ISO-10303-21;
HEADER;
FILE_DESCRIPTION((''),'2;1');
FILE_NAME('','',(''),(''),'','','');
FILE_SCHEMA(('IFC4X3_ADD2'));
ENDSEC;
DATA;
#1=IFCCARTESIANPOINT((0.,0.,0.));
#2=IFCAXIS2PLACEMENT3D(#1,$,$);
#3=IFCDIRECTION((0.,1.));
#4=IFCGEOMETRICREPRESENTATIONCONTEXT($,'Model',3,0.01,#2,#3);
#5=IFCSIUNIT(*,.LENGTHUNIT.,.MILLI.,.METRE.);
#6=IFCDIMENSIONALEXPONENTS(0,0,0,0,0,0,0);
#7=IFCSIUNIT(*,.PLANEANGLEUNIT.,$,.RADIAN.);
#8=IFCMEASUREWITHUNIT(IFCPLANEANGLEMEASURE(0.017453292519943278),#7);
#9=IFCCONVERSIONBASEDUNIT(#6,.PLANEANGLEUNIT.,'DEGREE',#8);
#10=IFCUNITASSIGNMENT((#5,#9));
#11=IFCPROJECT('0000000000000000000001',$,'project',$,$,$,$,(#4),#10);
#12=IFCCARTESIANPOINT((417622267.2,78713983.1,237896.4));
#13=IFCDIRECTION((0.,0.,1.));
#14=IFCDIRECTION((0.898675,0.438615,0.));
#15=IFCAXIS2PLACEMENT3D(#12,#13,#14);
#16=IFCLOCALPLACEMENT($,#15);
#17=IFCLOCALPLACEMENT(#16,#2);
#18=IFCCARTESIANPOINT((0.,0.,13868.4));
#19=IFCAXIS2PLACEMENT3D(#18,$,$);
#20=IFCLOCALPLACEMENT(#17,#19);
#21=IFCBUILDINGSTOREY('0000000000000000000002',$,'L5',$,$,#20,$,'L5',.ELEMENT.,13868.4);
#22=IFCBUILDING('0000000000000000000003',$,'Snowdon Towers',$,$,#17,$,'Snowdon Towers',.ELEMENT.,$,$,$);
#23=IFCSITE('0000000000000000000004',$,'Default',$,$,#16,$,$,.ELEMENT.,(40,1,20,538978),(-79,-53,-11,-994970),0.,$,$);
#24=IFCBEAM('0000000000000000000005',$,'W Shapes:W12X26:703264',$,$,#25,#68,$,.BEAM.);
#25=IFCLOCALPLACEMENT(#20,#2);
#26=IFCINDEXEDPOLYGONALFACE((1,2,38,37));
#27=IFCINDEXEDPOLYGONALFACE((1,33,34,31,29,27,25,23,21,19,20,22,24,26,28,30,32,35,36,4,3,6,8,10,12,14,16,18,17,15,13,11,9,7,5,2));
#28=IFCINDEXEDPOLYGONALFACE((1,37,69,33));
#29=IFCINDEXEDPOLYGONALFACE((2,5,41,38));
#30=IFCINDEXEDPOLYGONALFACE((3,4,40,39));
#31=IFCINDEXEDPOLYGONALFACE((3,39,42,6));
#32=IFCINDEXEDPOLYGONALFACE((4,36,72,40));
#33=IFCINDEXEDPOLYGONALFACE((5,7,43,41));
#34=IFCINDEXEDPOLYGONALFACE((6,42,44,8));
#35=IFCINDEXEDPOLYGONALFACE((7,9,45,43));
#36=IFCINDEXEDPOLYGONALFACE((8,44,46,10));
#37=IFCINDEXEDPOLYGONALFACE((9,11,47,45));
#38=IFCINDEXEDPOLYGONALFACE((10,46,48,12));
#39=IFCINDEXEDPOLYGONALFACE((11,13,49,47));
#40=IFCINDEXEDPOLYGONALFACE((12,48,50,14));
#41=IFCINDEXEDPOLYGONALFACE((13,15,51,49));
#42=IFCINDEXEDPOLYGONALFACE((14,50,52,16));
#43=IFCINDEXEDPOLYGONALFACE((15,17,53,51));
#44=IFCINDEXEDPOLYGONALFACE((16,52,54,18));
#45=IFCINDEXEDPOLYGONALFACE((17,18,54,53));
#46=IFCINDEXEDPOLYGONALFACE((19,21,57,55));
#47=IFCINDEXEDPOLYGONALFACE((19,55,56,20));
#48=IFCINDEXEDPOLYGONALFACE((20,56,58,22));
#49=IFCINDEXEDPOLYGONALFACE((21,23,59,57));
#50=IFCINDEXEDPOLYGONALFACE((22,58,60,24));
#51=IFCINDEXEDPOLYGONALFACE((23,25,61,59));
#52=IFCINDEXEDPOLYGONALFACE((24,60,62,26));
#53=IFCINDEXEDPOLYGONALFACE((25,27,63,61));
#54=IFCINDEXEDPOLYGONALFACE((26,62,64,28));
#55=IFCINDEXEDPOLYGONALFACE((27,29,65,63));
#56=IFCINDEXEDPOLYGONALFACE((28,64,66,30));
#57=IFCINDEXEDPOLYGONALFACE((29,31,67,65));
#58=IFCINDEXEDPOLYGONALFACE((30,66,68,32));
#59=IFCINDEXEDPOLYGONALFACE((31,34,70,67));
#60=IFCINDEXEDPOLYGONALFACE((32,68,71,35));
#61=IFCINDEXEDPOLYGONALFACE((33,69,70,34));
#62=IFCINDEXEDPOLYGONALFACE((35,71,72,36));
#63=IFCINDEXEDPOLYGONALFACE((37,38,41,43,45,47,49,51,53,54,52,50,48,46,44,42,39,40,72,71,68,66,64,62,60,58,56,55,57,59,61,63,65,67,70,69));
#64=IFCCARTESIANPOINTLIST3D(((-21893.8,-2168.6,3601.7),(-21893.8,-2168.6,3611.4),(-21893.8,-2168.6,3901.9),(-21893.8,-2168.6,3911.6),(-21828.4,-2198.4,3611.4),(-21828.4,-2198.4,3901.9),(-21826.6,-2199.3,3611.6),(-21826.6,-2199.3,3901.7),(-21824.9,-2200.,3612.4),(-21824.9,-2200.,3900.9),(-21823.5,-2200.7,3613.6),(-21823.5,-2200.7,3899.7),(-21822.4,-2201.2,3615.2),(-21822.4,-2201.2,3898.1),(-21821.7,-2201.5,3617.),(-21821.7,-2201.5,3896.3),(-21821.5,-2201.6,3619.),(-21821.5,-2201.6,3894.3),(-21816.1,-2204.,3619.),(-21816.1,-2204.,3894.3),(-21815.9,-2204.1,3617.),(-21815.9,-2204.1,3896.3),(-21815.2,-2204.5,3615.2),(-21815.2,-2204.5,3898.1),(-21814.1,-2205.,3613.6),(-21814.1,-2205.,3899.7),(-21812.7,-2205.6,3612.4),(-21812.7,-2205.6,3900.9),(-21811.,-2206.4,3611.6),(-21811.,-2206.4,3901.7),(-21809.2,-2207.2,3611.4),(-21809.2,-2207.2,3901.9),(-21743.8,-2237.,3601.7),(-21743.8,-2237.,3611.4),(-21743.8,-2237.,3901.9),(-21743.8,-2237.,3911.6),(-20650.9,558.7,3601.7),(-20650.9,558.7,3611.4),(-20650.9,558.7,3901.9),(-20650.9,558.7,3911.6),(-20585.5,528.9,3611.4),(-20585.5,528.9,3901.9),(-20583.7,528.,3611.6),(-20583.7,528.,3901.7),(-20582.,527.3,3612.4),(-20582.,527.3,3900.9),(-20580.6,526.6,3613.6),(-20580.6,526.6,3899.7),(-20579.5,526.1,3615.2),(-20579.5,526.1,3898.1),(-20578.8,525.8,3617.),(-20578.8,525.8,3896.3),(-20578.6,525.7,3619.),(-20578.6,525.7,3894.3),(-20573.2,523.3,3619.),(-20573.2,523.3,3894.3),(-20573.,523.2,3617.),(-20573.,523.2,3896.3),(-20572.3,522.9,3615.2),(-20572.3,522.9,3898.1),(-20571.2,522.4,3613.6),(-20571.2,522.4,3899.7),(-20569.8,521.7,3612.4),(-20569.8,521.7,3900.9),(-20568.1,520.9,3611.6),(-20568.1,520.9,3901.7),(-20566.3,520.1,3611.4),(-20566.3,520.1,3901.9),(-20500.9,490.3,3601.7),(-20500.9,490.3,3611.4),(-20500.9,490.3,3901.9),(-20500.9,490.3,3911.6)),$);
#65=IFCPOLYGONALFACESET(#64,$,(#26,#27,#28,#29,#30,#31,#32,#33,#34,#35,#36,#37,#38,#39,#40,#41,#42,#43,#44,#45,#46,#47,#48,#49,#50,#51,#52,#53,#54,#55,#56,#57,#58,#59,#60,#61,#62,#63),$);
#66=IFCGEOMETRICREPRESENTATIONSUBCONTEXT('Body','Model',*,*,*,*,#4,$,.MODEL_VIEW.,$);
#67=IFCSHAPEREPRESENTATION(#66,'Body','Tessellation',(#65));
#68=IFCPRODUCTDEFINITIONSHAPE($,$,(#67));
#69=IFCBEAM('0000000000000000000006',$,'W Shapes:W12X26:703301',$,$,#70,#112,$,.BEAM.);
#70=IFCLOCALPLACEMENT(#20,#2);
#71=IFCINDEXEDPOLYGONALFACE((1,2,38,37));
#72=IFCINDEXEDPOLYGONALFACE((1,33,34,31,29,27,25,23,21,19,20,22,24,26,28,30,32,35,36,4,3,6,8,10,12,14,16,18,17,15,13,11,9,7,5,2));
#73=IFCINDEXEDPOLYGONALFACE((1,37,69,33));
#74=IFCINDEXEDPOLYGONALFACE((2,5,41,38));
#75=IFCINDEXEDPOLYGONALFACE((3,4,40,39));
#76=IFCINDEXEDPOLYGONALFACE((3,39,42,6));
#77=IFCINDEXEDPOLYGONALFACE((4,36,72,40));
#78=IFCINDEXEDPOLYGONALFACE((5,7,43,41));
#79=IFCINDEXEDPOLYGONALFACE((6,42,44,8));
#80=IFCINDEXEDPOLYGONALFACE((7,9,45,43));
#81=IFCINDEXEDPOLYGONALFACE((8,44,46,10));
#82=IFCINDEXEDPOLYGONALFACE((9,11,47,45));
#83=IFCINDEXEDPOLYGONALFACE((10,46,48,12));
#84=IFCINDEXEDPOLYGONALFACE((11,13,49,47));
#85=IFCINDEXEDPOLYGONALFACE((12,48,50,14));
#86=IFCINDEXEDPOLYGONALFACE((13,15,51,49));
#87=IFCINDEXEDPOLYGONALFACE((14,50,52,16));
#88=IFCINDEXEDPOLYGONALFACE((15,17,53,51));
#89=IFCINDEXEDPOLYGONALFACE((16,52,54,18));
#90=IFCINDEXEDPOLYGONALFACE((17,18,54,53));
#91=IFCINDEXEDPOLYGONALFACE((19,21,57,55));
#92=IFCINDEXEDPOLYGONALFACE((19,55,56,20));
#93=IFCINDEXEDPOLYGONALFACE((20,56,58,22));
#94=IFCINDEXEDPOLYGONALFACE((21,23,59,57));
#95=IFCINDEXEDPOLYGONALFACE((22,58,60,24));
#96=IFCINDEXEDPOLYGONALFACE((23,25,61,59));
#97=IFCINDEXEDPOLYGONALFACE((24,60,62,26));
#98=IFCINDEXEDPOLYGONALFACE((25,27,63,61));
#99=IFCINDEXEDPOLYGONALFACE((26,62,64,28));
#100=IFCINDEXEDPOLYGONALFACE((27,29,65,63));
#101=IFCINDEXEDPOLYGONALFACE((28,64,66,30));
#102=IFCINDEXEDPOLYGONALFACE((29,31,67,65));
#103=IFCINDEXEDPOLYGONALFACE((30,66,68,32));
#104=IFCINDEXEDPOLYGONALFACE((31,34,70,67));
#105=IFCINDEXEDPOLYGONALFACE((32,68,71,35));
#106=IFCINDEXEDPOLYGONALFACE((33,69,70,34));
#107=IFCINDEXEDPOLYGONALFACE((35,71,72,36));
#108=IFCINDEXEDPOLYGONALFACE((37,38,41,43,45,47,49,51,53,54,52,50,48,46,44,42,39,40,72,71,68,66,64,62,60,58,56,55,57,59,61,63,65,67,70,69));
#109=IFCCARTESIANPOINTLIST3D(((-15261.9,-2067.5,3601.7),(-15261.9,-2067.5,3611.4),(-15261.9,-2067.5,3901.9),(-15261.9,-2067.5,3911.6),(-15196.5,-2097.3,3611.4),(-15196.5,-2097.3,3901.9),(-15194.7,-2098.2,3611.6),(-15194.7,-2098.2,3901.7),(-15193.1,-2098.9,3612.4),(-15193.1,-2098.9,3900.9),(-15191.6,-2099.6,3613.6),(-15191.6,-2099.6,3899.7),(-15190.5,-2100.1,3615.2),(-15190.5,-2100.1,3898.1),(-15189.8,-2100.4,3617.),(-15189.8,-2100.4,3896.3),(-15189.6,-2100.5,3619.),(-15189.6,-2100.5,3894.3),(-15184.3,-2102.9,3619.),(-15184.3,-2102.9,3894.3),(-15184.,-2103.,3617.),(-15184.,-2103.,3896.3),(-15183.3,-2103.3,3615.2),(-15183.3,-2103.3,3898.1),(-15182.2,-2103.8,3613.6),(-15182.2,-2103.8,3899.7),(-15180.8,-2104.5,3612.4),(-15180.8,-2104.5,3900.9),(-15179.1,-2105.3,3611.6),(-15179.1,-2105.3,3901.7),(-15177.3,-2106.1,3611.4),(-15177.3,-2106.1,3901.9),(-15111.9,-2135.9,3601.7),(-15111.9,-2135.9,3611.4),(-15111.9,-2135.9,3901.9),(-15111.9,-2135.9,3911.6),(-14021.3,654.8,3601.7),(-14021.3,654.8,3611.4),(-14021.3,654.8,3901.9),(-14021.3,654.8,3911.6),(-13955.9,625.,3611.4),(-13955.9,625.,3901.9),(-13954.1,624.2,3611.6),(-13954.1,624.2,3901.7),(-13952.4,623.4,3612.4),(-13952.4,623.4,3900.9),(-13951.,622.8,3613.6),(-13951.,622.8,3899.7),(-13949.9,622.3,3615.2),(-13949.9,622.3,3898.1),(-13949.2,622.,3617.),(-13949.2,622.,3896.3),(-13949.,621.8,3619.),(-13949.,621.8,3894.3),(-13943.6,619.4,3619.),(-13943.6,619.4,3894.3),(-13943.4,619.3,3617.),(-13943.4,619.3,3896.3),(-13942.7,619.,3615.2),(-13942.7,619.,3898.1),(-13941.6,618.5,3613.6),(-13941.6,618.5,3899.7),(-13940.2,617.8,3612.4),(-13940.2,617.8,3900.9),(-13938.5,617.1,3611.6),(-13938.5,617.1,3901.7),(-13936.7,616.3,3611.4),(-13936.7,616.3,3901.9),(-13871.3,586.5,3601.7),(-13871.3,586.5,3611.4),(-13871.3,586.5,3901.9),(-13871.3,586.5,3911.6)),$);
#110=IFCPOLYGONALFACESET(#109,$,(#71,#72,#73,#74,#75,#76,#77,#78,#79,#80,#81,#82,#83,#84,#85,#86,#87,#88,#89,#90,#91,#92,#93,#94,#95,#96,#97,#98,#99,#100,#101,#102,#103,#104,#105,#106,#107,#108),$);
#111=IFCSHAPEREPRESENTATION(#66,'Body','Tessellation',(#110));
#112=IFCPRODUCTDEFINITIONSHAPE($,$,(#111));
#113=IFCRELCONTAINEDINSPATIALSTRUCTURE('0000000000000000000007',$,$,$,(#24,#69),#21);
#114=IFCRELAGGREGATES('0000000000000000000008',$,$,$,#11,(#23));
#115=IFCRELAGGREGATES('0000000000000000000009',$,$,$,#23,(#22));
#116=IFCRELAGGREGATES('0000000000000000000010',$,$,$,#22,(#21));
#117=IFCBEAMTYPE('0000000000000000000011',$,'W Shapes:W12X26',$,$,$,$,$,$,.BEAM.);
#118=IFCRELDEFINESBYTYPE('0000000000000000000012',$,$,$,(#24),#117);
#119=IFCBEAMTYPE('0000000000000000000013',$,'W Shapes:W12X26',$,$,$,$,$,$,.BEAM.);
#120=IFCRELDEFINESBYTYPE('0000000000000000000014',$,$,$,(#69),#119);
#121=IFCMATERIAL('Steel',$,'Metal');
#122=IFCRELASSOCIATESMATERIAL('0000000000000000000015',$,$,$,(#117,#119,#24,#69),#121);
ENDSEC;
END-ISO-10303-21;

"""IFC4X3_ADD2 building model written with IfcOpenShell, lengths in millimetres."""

from ifc_helpers import new_model, entity, si_unit, converted_unit, direction, frame, frame_2d, origin, place, context, subcontext, project, spatial, polyline, circle_curve, parameter, trimmed, segment, composite_curve, outline, extrude, source, transform, mapped, material, material_profile, profile_set, profile_usage, type_object, type_shapes, element, save


model = new_model("IFC4X3_ADD2")

# Units and contexts
model_context = context("Model", 3, precision=0.01, world=origin(), true_north=direction((0.0, 1.0)))
body_context = subcontext(model_context, "Body", "Model", "MODEL_VIEW")
ifc_project = project(units=[si_unit("LENGTHUNIT", "METRE", prefix="MILLI"), converted_unit("PLANEANGLEUNIT", "DEGREE", entity("IfcPlaneAngleMeasure", 0.017453292519943278), si_unit("PLANEANGLEUNIT", "RADIAN"), dimensions=[0, 0, 0, 0, 0, 0, 0])], contexts=[model_context])

# Site, building, storey
site_placement = place(None, frame((417622267.2, 78713983.1, 237896.4), z_axis=(0.0, 0.0, 1.0), x_axis=(0.898675, 0.438615, 0.0)))
site = spatial("IfcSite", under=ifc_project, at=site_placement, Name="Default", CompositionType="ELEMENT", RefLatitude=(40, 1, 20, 538978), RefLongitude=(-79, -53, -11, -994970), RefElevation=0.0)
building_placement = place(site_placement, origin())
building = spatial("IfcBuilding", under=site, at=building_placement, Name="Snowdon Towers", LongName="Snowdon Towers", CompositionType="ELEMENT")
storey_placement = place(building_placement, frame((0.0, 0.0, 13868.4)))
storey = spatial("IfcBuildingStorey", under=building, at=storey_placement, Name="L5", LongName="L5", CompositionType="ELEMENT", Elevation=13868.4)

# Beams
ifc_material_1 = material(Name="Steel", Category="Metal")
ifc_material_profile_1 = material_profile(ifc_material_1, outline(composite_curve([segment(polyline([(-82.4, -145.3), (-82.4, -154.9)]), True, "CONTINUOUS"), segment(polyline([(-82.4, -154.9), (82.4, -154.9)]), True, "CONTINUOUS"), segment(polyline([(82.4, -154.9), (82.4, -145.3)]), True, "CONTINUOUS"), segment(polyline([(82.4, -145.3), (10.5, -145.3)]), True, "CONTINUOUS"), segment(trimmed(circle_curve(frame_2d((10.5, -137.7), x_axis=(1.0, 0.0)), 7.6), [parameter(180.0)], [parameter(270.0)], True, "PARAMETER"), False, "CONTINUOUS"), segment(polyline([(2.9, -137.7), (2.9, 137.7)]), True, "CONTINUOUS"), segment(trimmed(circle_curve(frame_2d((10.5, 137.7), x_axis=(1.0, 0.0)), 7.6), [parameter(90.0)], [parameter(180.0)], True, "PARAMETER"), False, "CONTINUOUS"), segment(polyline([(10.5, 145.3), (82.4, 145.3)]), True, "CONTINUOUS"), segment(polyline([(82.4, 145.3), (82.4, 154.9)]), True, "CONTINUOUS"), segment(polyline([(82.4, 154.9), (-82.4, 154.9)]), True, "CONTINUOUS"), segment(polyline([(-82.4, 154.9), (-82.4, 145.3)]), True, "CONTINUOUS"), segment(polyline([(-82.4, 145.3), (-10.5, 145.3)]), True, "CONTINUOUS"), segment(trimmed(circle_curve(frame_2d((-10.5, 137.7), x_axis=(1.0, 0.0)), 7.6), [parameter(360.0)], [parameter(90.0)], True, "PARAMETER"), False, "CONTINUOUS"), segment(polyline([(-2.9, 137.7), (-2.9, -137.7)]), True, "CONTINUOUS"), segment(trimmed(circle_curve(frame_2d((-10.5, -137.7), x_axis=(1.0, 0.0)), 7.6), [parameter(270.0)], [parameter(360.0)], True, "PARAMETER"), False, "CONTINUOUS"), segment(polyline([(-10.5, -145.3), (-82.4, -145.3)]), True, "CONTINUOUS")], self_intersect=False)), Name="W12X26")
ifc_profile_set_1 = profile_set([ifc_material_profile_1], Name="W12X26")
ifc_profile_usage_1 = profile_usage(ifc_profile_set_1, cardinal=8)
beam_type_1 = type_object("IfcBeamType", Name="W Shapes:W12X26", PredefinedType="BEAM", material=ifc_profile_set_1)
shared_shape_1 = source(origin(), body_context, "Body", "SweptSolid", [
    extrude(outline(composite_curve([segment(polyline([(-82.4, -145.3), (-82.4, -154.9)]), True, "CONTINUOUS"), segment(polyline([(-82.4, -154.9), (82.4, -154.9)]), True, "CONTINUOUS"), segment(polyline([(82.4, -154.9), (82.4, -145.3)]), True, "CONTINUOUS"), segment(polyline([(82.4, -145.3), (10.5, -145.3)]), True, "CONTINUOUS"), segment(trimmed(circle_curve(frame_2d((10.5, -137.7), x_axis=(0.0, -1.0)), 7.6), [parameter(270.0)], [parameter(360.0)], True, "PARAMETER"), False, "CONTINUOUS"), segment(polyline([(2.9, -137.7), (2.9, 137.7)]), True, "CONTINUOUS"), segment(trimmed(circle_curve(frame_2d((10.5, 137.7), x_axis=(-1.0, 0.0)), 7.6), [parameter(270.0)], [parameter(360.0)], True, "PARAMETER"), False, "CONTINUOUS"), segment(polyline([(10.5, 145.3), (82.4, 145.3)]), True, "CONTINUOUS"), segment(polyline([(82.4, 145.3), (82.4, 154.9)]), True, "CONTINUOUS"), segment(polyline([(82.4, 154.9), (-82.4, 154.9)]), True, "CONTINUOUS"), segment(polyline([(-82.4, 154.9), (-82.4, 145.3)]), True, "CONTINUOUS"), segment(polyline([(-82.4, 145.3), (-10.5, 145.3)]), True, "CONTINUOUS"), segment(trimmed(circle_curve(frame_2d((-10.5, 137.7), x_axis=(0.0, 1.0)), 7.6), [parameter(270.0)], [parameter(0.0)], True, "PARAMETER"), False, "CONTINUOUS"), segment(polyline([(-2.9, 137.7), (-2.9, -137.7)]), True, "CONTINUOUS"), segment(trimmed(circle_curve(frame_2d((-10.5, -137.7), x_axis=(1.0, 0.0)), 7.6), [parameter(270.0)], [parameter(0.0)], True, "PARAMETER"), False, "CONTINUOUS"), segment(polyline([(-10.5, -145.3), (-82.4, -145.3)]), True, "CONTINUOUS")], self_intersect=False)), frame((-1581.5, 0.0, 0.0), z_axis=(-1.0, 0.0, 0.0), x_axis=(0.0, -1.0, 0.0)), (0.0, 0.0, -1.0), 2997.2),
])
type_shapes(beam_type_1, [shared_shape_1])
beam_1_placement = place(storey_placement, frame((-21163.0, -763.7, 3756.7), z_axis=(0.0, 0.0, 1.0), x_axis=(0.414693, 0.909961, 0.0)))
element("IfcBeam", 1, at=beam_1_placement, inside=storey, type_object=beam_type_1, material=ifc_profile_usage_1, Name="W Shapes:W12X26:703264", PredefinedType="BEAM", context=body_context, shape_type="MappedRepresentation", body=[
    mapped(shared_shape_1, transform((0.0, 0.0, 0.0), scale=1.0)),
])
beam_type_2 = type_object("IfcBeamType", Name="W Shapes:W12X26", PredefinedType="BEAM", material=ifc_profile_set_1)
shared_shape_2 = source(origin(), body_context, "Body", "SweptSolid", [
    extrude(outline(composite_curve([segment(polyline([(-82.4, -145.3), (-82.4, -154.9)]), True, "CONTINUOUS"), segment(polyline([(-82.4, -154.9), (82.4, -154.9)]), True, "CONTINUOUS"), segment(polyline([(82.4, -154.9), (82.4, -145.3)]), True, "CONTINUOUS"), segment(polyline([(82.4, -145.3), (10.5, -145.3)]), True, "CONTINUOUS"), segment(trimmed(circle_curve(frame_2d((10.5, -137.7), x_axis=(1.0, 0.0)), 7.6), [parameter(180.0)], [parameter(270.0)], True, "PARAMETER"), False, "CONTINUOUS"), segment(polyline([(2.9, -137.7), (2.9, 137.7)]), True, "CONTINUOUS"), segment(trimmed(circle_curve(frame_2d((10.5, 137.7), x_axis=(1.0, 0.0)), 7.6), [parameter(90.0)], [parameter(180.0)], True, "PARAMETER"), False, "CONTINUOUS"), segment(polyline([(10.5, 145.3), (82.4, 145.3)]), True, "CONTINUOUS"), segment(polyline([(82.4, 145.3), (82.4, 154.9)]), True, "CONTINUOUS"), segment(polyline([(82.4, 154.9), (-82.4, 154.9)]), True, "CONTINUOUS"), segment(polyline([(-82.4, 154.9), (-82.4, 145.3)]), True, "CONTINUOUS"), segment(polyline([(-82.4, 145.3), (-10.5, 145.3)]), True, "CONTINUOUS"), segment(trimmed(circle_curve(frame_2d((-10.5, 137.7), x_axis=(1.0, 0.0)), 7.6), [parameter(360.0)], [parameter(90.0)], True, "PARAMETER"), False, "CONTINUOUS"), segment(polyline([(-2.9, 137.7), (-2.9, -137.7)]), True, "CONTINUOUS"), segment(trimmed(circle_curve(frame_2d((-10.5, -137.7), x_axis=(1.0, 0.0)), 7.6), [parameter(270.0)], [parameter(360.0)], True, "PARAMETER"), False, "CONTINUOUS"), segment(polyline([(-10.5, -145.3), (-82.4, -145.3)]), True, "CONTINUOUS")], self_intersect=False)), frame((-1516.7, 0.0, 0.0), z_axis=(-1.0, 0.0, 0.0), x_axis=(0.0, -1.0, 0.0)), (0.0, 0.0, -1.0), 2991.7),
])
type_shapes(beam_type_2, [shared_shape_2])
beam_2_placement = place(storey_placement, frame((-14558.0, -721.5, 3756.7), z_axis=(0.0, 0.0, 1.0), x_axis=(0.414693, 0.909961, 0.0)))
element("IfcBeam", 2, at=beam_2_placement, inside=storey, type_object=beam_type_2, material=ifc_profile_usage_1, Name="W Shapes:W12X26:703301", PredefinedType="BEAM", context=body_context, shape_type="MappedRepresentation", body=[
    mapped(shared_shape_2, transform((0.0, 0.0, 0.0), scale=1.0)),
])

save(model, "model.ifc")
